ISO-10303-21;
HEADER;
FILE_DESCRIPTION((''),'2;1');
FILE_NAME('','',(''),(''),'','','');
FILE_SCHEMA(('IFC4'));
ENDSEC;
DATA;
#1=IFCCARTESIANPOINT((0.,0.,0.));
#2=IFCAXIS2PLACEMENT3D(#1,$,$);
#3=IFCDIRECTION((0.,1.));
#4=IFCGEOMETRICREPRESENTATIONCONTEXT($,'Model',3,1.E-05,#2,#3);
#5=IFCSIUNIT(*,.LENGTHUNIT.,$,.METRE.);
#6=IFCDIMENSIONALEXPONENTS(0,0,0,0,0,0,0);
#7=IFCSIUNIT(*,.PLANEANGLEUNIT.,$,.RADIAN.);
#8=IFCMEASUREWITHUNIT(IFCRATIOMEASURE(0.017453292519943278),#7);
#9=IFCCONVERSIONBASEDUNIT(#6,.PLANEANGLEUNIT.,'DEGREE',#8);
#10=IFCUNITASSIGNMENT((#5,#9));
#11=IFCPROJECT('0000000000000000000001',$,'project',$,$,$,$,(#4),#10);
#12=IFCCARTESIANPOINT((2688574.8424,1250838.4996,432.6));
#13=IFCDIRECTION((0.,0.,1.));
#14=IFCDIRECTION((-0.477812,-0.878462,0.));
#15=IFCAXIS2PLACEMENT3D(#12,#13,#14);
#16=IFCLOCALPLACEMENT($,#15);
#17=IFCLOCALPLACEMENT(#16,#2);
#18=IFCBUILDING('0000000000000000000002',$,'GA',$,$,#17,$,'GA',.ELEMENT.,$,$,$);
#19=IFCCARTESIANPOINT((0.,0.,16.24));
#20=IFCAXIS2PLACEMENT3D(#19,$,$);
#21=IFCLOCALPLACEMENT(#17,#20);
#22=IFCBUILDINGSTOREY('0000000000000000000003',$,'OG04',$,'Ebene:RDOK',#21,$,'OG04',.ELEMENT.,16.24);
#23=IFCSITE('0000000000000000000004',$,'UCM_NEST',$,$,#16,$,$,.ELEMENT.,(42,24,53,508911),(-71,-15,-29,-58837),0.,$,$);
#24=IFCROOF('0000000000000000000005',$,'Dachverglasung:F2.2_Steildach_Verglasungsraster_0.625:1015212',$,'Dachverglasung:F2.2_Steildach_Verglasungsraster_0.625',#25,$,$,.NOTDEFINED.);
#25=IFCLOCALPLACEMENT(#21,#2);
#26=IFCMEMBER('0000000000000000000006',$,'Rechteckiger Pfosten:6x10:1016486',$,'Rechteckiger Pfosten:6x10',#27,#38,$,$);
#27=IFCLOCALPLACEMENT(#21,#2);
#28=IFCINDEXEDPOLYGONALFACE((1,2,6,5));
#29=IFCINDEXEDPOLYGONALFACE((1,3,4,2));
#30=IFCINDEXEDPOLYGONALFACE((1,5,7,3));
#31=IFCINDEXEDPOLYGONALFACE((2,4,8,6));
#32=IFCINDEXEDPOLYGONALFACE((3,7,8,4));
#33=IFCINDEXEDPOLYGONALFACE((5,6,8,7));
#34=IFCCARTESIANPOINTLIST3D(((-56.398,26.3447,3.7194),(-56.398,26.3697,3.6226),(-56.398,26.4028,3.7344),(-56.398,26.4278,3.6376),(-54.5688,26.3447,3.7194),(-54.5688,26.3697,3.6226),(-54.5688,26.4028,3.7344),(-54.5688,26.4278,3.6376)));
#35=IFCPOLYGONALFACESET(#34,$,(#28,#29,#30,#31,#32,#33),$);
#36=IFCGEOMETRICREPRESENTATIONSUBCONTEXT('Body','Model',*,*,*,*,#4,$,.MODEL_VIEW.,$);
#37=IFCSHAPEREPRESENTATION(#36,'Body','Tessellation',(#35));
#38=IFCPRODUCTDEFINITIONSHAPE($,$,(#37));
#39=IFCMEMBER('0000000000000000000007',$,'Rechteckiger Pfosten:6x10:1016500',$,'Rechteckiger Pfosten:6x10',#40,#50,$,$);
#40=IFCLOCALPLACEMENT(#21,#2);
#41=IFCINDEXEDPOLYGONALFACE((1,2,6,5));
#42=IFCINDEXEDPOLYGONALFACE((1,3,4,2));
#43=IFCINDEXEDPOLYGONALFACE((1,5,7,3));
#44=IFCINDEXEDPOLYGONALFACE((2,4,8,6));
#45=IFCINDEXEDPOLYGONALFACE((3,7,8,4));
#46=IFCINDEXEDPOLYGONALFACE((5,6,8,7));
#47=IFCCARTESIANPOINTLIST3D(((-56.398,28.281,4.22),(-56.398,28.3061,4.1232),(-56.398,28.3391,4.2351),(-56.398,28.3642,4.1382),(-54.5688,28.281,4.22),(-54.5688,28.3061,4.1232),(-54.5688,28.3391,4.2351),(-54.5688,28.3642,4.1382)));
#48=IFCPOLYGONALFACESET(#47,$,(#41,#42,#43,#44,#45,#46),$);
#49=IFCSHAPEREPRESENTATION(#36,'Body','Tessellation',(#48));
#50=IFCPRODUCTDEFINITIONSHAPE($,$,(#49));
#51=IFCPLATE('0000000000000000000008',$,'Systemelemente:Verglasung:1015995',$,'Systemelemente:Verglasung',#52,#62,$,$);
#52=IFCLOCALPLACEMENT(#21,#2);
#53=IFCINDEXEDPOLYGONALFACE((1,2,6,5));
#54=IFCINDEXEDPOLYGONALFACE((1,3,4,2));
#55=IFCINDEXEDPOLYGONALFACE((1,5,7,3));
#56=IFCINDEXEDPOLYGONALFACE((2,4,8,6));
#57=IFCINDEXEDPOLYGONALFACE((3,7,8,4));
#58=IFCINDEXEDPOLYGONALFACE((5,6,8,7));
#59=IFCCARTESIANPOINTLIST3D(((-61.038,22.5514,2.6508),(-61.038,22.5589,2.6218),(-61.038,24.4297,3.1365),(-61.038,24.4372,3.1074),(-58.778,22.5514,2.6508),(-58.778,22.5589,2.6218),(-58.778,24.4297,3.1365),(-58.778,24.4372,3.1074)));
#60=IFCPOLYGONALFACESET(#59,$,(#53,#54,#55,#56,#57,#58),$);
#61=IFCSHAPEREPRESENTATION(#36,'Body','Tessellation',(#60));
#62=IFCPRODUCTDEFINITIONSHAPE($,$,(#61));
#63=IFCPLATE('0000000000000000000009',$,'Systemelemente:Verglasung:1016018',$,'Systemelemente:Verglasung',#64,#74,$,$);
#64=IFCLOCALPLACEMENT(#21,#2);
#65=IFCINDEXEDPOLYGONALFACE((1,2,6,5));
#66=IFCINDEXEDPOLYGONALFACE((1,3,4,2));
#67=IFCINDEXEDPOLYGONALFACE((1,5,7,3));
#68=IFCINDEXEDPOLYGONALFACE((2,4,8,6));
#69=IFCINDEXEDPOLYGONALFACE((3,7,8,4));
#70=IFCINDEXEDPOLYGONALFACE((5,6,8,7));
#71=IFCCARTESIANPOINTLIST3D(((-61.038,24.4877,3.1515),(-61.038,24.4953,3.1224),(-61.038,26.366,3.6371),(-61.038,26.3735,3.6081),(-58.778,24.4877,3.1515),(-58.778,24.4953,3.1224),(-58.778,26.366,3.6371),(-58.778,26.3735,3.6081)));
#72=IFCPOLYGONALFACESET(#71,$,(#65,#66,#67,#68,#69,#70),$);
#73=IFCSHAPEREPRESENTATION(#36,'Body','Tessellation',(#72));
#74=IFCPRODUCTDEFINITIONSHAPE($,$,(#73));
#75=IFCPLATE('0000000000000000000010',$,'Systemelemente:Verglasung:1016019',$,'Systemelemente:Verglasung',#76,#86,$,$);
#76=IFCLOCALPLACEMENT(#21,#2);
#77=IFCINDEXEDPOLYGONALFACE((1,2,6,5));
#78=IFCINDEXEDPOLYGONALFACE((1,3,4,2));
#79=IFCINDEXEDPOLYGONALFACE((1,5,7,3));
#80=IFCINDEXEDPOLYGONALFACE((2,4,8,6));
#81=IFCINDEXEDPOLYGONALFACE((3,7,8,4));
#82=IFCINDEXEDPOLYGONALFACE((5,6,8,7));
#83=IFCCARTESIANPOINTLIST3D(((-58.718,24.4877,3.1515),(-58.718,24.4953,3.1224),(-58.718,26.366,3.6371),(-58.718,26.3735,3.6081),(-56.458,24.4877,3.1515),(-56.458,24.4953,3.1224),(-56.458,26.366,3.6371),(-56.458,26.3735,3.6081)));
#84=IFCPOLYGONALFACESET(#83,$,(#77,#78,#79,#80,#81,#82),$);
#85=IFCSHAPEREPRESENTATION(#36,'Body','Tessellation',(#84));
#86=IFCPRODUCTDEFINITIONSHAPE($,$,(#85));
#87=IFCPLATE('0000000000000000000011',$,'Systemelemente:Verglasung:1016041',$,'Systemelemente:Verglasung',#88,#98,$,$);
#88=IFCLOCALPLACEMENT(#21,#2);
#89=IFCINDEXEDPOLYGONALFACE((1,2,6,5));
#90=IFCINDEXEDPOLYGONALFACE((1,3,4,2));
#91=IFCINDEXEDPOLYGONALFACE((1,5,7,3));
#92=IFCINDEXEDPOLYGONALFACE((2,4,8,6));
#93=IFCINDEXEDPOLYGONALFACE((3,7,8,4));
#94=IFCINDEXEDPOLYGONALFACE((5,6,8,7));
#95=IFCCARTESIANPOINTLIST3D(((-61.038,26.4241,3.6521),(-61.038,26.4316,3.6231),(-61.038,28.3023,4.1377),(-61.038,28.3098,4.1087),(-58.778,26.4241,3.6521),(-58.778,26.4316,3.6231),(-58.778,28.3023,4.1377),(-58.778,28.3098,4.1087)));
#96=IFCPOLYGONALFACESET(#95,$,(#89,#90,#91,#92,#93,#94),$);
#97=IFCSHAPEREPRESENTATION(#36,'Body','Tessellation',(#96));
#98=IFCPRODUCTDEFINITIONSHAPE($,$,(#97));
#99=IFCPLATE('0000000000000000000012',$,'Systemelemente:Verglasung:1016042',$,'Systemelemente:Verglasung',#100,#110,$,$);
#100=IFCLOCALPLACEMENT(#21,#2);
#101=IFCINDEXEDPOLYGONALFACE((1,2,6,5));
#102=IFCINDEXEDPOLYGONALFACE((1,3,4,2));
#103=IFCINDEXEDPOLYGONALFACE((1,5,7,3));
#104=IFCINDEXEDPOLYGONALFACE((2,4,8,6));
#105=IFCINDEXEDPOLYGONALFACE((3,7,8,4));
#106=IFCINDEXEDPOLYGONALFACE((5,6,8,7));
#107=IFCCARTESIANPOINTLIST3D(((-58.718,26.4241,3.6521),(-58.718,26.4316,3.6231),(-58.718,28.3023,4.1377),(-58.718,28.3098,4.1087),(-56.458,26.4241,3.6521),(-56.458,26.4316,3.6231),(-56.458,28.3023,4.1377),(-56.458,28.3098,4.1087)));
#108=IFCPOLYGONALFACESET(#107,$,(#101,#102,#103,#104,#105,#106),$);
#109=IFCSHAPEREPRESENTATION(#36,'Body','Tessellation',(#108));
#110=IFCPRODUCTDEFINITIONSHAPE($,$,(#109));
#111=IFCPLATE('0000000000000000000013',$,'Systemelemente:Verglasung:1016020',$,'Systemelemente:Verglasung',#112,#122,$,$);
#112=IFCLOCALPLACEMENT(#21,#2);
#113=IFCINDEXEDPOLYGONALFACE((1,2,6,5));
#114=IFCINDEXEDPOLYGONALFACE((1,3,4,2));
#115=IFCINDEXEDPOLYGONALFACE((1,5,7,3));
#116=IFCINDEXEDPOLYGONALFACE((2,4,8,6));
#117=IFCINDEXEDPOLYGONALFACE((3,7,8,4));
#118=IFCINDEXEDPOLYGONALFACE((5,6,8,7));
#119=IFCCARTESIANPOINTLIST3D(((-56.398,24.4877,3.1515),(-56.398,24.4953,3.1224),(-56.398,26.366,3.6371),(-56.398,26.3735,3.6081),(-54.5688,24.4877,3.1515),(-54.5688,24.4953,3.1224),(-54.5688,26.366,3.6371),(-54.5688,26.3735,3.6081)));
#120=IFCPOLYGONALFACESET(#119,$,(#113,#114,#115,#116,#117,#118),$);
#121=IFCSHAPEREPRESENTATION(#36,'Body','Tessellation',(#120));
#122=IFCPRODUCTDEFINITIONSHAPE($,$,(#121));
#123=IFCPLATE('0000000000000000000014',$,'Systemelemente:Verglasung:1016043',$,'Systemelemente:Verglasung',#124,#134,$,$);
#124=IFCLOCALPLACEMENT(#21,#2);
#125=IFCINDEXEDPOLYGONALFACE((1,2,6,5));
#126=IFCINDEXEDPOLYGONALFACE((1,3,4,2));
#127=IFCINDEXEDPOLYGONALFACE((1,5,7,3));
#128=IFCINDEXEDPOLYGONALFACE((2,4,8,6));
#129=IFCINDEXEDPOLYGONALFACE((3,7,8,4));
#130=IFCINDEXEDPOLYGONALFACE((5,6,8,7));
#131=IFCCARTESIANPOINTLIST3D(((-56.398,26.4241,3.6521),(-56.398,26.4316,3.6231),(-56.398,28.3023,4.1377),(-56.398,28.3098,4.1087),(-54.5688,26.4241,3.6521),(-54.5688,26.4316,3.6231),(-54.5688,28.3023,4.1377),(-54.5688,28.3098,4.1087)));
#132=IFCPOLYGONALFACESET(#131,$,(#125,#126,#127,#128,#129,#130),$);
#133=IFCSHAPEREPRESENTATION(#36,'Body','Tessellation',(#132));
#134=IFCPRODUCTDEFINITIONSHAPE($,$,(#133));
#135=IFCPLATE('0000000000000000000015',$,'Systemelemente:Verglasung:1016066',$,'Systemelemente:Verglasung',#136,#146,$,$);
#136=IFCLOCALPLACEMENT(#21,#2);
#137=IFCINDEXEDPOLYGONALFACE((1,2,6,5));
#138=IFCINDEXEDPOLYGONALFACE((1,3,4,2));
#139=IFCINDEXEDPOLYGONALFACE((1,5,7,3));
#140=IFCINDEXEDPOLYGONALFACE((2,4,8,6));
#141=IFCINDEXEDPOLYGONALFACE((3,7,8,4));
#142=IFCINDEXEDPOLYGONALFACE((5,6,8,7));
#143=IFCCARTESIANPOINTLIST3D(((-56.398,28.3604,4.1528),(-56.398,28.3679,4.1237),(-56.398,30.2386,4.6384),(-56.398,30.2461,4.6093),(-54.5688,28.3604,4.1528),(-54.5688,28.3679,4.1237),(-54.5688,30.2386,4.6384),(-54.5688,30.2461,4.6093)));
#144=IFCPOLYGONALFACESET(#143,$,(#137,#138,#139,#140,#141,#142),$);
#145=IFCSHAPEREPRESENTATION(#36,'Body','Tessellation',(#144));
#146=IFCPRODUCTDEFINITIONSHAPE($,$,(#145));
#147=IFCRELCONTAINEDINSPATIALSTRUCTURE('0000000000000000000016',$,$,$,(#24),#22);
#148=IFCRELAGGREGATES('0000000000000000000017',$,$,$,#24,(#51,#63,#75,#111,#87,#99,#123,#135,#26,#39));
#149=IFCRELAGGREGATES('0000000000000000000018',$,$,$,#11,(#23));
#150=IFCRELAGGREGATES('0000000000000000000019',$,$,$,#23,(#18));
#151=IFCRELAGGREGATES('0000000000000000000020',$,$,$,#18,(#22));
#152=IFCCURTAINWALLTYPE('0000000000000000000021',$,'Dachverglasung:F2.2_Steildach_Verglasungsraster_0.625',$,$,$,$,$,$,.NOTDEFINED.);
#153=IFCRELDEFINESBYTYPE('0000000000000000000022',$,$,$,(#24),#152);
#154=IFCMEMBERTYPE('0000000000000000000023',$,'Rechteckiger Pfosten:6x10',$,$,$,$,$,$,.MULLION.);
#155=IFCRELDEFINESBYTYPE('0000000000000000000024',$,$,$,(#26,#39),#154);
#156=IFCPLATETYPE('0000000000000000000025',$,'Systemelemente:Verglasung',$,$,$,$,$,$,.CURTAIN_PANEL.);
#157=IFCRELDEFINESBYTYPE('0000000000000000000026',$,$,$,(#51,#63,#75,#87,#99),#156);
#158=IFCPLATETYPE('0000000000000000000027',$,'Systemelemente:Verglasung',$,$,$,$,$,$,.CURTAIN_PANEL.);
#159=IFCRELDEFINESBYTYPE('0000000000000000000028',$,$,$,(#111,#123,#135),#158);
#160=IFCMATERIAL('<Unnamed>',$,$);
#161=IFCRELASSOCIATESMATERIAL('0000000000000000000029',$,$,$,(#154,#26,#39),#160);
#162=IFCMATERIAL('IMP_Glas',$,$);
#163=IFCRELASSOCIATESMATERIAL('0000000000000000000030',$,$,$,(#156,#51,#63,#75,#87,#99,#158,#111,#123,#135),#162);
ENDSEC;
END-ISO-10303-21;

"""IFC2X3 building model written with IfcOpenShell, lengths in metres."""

from ifc_helpers import new_model, entity, si_unit, converted_unit, direction, frame, origin, origin_2d_with_axis, place, context, subcontext, project, spatial, rectangle, extrude, source, transform, mapped, material, type_object, type_shapes, element, aggregate, save


model = new_model("IFC2X3")

# Units and contexts
model_context = context("Model", 3, precision=1e-05, world=origin(), true_north=direction((0.0, 1.0)))
body_context = subcontext(model_context, "Body", "Model", "MODEL_VIEW")
ifc_project = project(units=[si_unit("LENGTHUNIT", "METRE"), converted_unit("PLANEANGLEUNIT", "DEGREE", entity("IfcRatioMeasure", 0.017453292519943278), si_unit("PLANEANGLEUNIT", "RADIAN"), dimensions=[0, 0, 0, 0, 0, 0, 0])], contexts=[model_context])

# Site, building, storey
site_placement = place(None, frame((2688574.8424, 1250838.4996, 432.6), z_axis=(0.0, 0.0, 1.0), x_axis=(-0.477812, -0.878462, 0.0)))
site = spatial("IfcSite", under=ifc_project, at=site_placement, Name="UCM_NEST", CompositionType="ELEMENT", RefLatitude=(42, 24, 53, 508911), RefLongitude=(-71, -15, -29, -58837), RefElevation=0.0)
building_placement = place(site_placement, origin())
building = spatial("IfcBuilding", under=site, at=building_placement, Name="GA", LongName="GA", CompositionType="ELEMENT")
storey_placement = place(building_placement, frame((0.0, 0.0, 16.24)))
storey = spatial("IfcBuildingStorey", under=building, at=storey_placement, Name="OG04", ObjectType="Ebene:RDOK", LongName="OG04", CompositionType="ELEMENT", Elevation=16.24)

# Roof, members, plates
curtain_wall_type = type_object("IfcCurtainWallType", Name="Dachverglasung:F2.2_Steildach_Verglasungsraster_0.625", PredefinedType="NOTDEFINED")
roof_placement = place(storey_placement, frame((0.0, 0.0, -16.24)))
roof = element("IfcRoof", 1, at=roof_placement, inside=storey, type_object=curtain_wall_type, Name="Dachverglasung:F2.2_Steildach_Verglasungsraster_0.625:1015212", ObjectType="Dachverglasung:F2.2_Steildach_Verglasungsraster_0.625", ShapeType="NOTDEFINED")
ifc_material_1 = material(Name="<Unnamed>")
member_type_1 = type_object("IfcMemberType", Name="Rechteckiger Pfosten:6x10", PredefinedType="MULLION", material=ifc_material_1)
shared_shape_1 = source(origin(), body_context, "Body", "SweptSolid", [
    extrude(rectangle(XDim=0.1, YDim=0.06, at=origin_2d_with_axis()), frame((-0.03, -0.05, -1.8292), z_axis=(0.0, 0.0, 1.0), x_axis=(0.0, -1.0, 0.0)), (0.0, 0.0, 1.0), 1.8292),
])
type_shapes(member_type_1, [shared_shape_1])
member_1_placement = place(roof_placement, frame((-56.398, 26.4278, 19.8776), z_axis=(-1.0, 0.0, 0.0), x_axis=(0.0, 0.968163, 0.250322)))
member_1 = element("IfcMember", 2, at=member_1_placement, type_object=member_type_1, material=ifc_material_1, Name="Rechteckiger Pfosten:6x10:1016486", ObjectType="Rechteckiger Pfosten:6x10", context=body_context, shape_type="MappedRepresentation", body=[
    mapped(shared_shape_1, transform((0.0, 0.0, 0.0), scale=1.0)),
])
member_2_placement = place(roof_placement, frame((-56.398, 28.3642, 20.3782), z_axis=(-1.0, 0.0, 0.0), x_axis=(0.0, 0.968163, 0.250322)))
member_2 = element("IfcMember", 3, at=member_2_placement, type_object=member_type_1, material=ifc_material_1, Name="Rechteckiger Pfosten:6x10:1016500", ObjectType="Rechteckiger Pfosten:6x10", context=body_context, shape_type="MappedRepresentation", body=[
    mapped(shared_shape_1, transform((0.0, 0.0, 0.0), scale=1.0)),
])
ifc_material_2 = material(Name="IMP_Glas")
plate_type_1 = type_object("IfcPlateType", Name="Systemelemente:Verglasung", PredefinedType="CURTAIN_PANEL", material=ifc_material_2)
shared_shape_2 = source(origin(), body_context, "Body", "SweptSolid", [
    extrude(rectangle(XDim=0.03, YDim=2.26, at=origin_2d_with_axis()), frame((0.0, 0.0, 0.0), z_axis=(0.0, 0.0, 1.0), x_axis=(0.0, 1.0, 0.0)), (0.0, 0.0, 1.0), 1.94),
])
type_shapes(plate_type_1, [shared_shape_2])
plate_1_placement = place(roof_placement, frame((-59.908, 22.5552, 18.8763), z_axis=(0.0, 0.968163, 0.250322), x_axis=(1.0, 0.0, 0.0)))
plate_1 = element("IfcPlate", 4, at=plate_1_placement, type_object=plate_type_1, material=ifc_material_2, Name="Systemelemente:Verglasung:1015995", ObjectType="Systemelemente:Verglasung", context=body_context, shape_type="MappedRepresentation", body=[
    mapped(shared_shape_2, transform((0.0, 0.0, 0.0), scale=1.0)),
])
plate_2_placement = place(roof_placement, frame((-59.908, 24.4915, 19.3769), z_axis=(0.0, 0.968163, 0.250322), x_axis=(1.0, 0.0, 0.0)))
plate_2 = element("IfcPlate", 5, at=plate_2_placement, type_object=plate_type_1, material=ifc_material_2, Name="Systemelemente:Verglasung:1016018", ObjectType="Systemelemente:Verglasung", context=body_context, shape_type="MappedRepresentation", body=[
    mapped(shared_shape_2, transform((0.0, 0.0, 0.0), scale=1.0)),
])
plate_3_placement = place(roof_placement, frame((-57.588, 24.4915, 19.3769), z_axis=(0.0, 0.968163, 0.250322), x_axis=(1.0, 0.0, 0.0)))
plate_3 = element("IfcPlate", 6, at=plate_3_placement, type_object=plate_type_1, material=ifc_material_2, Name="Systemelemente:Verglasung:1016019", ObjectType="Systemelemente:Verglasung", context=body_context, shape_type="MappedRepresentation", body=[
    mapped(shared_shape_2, transform((0.0, 0.0, 0.0), scale=1.0)),
])
plate_4_placement = place(roof_placement, frame((-59.908, 26.4278, 19.8776), z_axis=(0.0, 0.968163, 0.250322), x_axis=(1.0, 0.0, 0.0)))
plate_4 = element("IfcPlate", 7, at=plate_4_placement, type_object=plate_type_1, material=ifc_material_2, Name="Systemelemente:Verglasung:1016041", ObjectType="Systemelemente:Verglasung", context=body_context, shape_type="MappedRepresentation", body=[
    mapped(shared_shape_2, transform((0.0, 0.0, 0.0), scale=1.0)),
])
plate_5_placement = place(roof_placement, frame((-57.588, 26.4278, 19.8776), z_axis=(0.0, 0.968163, 0.250322), x_axis=(1.0, 0.0, 0.0)))
plate_5 = element("IfcPlate", 8, at=plate_5_placement, type_object=plate_type_1, material=ifc_material_2, Name="Systemelemente:Verglasung:1016042", ObjectType="Systemelemente:Verglasung", context=body_context, shape_type="MappedRepresentation", body=[
    mapped(shared_shape_2, transform((0.0, 0.0, 0.0), scale=1.0)),
])
plate_type_2 = type_object("IfcPlateType", Name="Systemelemente:Verglasung", PredefinedType="CURTAIN_PANEL", material=ifc_material_2)
shared_shape_3 = source(origin(), body_context, "Body", "SweptSolid", [
    extrude(rectangle(XDim=0.03, YDim=1.8292, at=origin_2d_with_axis()), frame((0.0, 0.0, 0.0), z_axis=(0.0, 0.0, 1.0), x_axis=(0.0, 1.0, 0.0)), (0.0, 0.0, 1.0), 1.94),
])
type_shapes(plate_type_2, [shared_shape_3])
plate_6_placement = place(roof_placement, frame((-55.4834, 24.4915, 19.3769), z_axis=(0.0, 0.968163, 0.250322), x_axis=(1.0, 0.0, 0.0)))
plate_6 = element("IfcPlate", 9, at=plate_6_placement, type_object=plate_type_2, material=ifc_material_2, Name="Systemelemente:Verglasung:1016020", ObjectType="Systemelemente:Verglasung", context=body_context, shape_type="MappedRepresentation", body=[
    mapped(shared_shape_3, transform((0.0, 0.0, 0.0), scale=1.0)),
])
plate_7_placement = place(roof_placement, frame((-55.4834, 26.4278, 19.8776), z_axis=(0.0, 0.968163, 0.250322), x_axis=(1.0, 0.0, 0.0)))
plate_7 = element("IfcPlate", 10, at=plate_7_placement, type_object=plate_type_2, material=ifc_material_2, Name="Systemelemente:Verglasung:1016043", ObjectType="Systemelemente:Verglasung", context=body_context, shape_type="MappedRepresentation", body=[
    mapped(shared_shape_3, transform((0.0, 0.0, 0.0), scale=1.0)),
])
plate_8_placement = place(roof_placement, frame((-55.4834, 28.3642, 20.3782), z_axis=(0.0, 0.968163, 0.250322), x_axis=(1.0, 0.0, 0.0)))
plate_8 = element("IfcPlate", 11, at=plate_8_placement, type_object=plate_type_2, material=ifc_material_2, Name="Systemelemente:Verglasung:1016066", ObjectType="Systemelemente:Verglasung", context=body_context, shape_type="MappedRepresentation", body=[
    mapped(shared_shape_3, transform((0.0, 0.0, 0.0), scale=1.0)),
])
aggregate(roof, [plate_1, plate_2, plate_3, plate_6, plate_4, plate_5, plate_7, plate_8, member_1, member_2])

save(model, "model.ifc")
